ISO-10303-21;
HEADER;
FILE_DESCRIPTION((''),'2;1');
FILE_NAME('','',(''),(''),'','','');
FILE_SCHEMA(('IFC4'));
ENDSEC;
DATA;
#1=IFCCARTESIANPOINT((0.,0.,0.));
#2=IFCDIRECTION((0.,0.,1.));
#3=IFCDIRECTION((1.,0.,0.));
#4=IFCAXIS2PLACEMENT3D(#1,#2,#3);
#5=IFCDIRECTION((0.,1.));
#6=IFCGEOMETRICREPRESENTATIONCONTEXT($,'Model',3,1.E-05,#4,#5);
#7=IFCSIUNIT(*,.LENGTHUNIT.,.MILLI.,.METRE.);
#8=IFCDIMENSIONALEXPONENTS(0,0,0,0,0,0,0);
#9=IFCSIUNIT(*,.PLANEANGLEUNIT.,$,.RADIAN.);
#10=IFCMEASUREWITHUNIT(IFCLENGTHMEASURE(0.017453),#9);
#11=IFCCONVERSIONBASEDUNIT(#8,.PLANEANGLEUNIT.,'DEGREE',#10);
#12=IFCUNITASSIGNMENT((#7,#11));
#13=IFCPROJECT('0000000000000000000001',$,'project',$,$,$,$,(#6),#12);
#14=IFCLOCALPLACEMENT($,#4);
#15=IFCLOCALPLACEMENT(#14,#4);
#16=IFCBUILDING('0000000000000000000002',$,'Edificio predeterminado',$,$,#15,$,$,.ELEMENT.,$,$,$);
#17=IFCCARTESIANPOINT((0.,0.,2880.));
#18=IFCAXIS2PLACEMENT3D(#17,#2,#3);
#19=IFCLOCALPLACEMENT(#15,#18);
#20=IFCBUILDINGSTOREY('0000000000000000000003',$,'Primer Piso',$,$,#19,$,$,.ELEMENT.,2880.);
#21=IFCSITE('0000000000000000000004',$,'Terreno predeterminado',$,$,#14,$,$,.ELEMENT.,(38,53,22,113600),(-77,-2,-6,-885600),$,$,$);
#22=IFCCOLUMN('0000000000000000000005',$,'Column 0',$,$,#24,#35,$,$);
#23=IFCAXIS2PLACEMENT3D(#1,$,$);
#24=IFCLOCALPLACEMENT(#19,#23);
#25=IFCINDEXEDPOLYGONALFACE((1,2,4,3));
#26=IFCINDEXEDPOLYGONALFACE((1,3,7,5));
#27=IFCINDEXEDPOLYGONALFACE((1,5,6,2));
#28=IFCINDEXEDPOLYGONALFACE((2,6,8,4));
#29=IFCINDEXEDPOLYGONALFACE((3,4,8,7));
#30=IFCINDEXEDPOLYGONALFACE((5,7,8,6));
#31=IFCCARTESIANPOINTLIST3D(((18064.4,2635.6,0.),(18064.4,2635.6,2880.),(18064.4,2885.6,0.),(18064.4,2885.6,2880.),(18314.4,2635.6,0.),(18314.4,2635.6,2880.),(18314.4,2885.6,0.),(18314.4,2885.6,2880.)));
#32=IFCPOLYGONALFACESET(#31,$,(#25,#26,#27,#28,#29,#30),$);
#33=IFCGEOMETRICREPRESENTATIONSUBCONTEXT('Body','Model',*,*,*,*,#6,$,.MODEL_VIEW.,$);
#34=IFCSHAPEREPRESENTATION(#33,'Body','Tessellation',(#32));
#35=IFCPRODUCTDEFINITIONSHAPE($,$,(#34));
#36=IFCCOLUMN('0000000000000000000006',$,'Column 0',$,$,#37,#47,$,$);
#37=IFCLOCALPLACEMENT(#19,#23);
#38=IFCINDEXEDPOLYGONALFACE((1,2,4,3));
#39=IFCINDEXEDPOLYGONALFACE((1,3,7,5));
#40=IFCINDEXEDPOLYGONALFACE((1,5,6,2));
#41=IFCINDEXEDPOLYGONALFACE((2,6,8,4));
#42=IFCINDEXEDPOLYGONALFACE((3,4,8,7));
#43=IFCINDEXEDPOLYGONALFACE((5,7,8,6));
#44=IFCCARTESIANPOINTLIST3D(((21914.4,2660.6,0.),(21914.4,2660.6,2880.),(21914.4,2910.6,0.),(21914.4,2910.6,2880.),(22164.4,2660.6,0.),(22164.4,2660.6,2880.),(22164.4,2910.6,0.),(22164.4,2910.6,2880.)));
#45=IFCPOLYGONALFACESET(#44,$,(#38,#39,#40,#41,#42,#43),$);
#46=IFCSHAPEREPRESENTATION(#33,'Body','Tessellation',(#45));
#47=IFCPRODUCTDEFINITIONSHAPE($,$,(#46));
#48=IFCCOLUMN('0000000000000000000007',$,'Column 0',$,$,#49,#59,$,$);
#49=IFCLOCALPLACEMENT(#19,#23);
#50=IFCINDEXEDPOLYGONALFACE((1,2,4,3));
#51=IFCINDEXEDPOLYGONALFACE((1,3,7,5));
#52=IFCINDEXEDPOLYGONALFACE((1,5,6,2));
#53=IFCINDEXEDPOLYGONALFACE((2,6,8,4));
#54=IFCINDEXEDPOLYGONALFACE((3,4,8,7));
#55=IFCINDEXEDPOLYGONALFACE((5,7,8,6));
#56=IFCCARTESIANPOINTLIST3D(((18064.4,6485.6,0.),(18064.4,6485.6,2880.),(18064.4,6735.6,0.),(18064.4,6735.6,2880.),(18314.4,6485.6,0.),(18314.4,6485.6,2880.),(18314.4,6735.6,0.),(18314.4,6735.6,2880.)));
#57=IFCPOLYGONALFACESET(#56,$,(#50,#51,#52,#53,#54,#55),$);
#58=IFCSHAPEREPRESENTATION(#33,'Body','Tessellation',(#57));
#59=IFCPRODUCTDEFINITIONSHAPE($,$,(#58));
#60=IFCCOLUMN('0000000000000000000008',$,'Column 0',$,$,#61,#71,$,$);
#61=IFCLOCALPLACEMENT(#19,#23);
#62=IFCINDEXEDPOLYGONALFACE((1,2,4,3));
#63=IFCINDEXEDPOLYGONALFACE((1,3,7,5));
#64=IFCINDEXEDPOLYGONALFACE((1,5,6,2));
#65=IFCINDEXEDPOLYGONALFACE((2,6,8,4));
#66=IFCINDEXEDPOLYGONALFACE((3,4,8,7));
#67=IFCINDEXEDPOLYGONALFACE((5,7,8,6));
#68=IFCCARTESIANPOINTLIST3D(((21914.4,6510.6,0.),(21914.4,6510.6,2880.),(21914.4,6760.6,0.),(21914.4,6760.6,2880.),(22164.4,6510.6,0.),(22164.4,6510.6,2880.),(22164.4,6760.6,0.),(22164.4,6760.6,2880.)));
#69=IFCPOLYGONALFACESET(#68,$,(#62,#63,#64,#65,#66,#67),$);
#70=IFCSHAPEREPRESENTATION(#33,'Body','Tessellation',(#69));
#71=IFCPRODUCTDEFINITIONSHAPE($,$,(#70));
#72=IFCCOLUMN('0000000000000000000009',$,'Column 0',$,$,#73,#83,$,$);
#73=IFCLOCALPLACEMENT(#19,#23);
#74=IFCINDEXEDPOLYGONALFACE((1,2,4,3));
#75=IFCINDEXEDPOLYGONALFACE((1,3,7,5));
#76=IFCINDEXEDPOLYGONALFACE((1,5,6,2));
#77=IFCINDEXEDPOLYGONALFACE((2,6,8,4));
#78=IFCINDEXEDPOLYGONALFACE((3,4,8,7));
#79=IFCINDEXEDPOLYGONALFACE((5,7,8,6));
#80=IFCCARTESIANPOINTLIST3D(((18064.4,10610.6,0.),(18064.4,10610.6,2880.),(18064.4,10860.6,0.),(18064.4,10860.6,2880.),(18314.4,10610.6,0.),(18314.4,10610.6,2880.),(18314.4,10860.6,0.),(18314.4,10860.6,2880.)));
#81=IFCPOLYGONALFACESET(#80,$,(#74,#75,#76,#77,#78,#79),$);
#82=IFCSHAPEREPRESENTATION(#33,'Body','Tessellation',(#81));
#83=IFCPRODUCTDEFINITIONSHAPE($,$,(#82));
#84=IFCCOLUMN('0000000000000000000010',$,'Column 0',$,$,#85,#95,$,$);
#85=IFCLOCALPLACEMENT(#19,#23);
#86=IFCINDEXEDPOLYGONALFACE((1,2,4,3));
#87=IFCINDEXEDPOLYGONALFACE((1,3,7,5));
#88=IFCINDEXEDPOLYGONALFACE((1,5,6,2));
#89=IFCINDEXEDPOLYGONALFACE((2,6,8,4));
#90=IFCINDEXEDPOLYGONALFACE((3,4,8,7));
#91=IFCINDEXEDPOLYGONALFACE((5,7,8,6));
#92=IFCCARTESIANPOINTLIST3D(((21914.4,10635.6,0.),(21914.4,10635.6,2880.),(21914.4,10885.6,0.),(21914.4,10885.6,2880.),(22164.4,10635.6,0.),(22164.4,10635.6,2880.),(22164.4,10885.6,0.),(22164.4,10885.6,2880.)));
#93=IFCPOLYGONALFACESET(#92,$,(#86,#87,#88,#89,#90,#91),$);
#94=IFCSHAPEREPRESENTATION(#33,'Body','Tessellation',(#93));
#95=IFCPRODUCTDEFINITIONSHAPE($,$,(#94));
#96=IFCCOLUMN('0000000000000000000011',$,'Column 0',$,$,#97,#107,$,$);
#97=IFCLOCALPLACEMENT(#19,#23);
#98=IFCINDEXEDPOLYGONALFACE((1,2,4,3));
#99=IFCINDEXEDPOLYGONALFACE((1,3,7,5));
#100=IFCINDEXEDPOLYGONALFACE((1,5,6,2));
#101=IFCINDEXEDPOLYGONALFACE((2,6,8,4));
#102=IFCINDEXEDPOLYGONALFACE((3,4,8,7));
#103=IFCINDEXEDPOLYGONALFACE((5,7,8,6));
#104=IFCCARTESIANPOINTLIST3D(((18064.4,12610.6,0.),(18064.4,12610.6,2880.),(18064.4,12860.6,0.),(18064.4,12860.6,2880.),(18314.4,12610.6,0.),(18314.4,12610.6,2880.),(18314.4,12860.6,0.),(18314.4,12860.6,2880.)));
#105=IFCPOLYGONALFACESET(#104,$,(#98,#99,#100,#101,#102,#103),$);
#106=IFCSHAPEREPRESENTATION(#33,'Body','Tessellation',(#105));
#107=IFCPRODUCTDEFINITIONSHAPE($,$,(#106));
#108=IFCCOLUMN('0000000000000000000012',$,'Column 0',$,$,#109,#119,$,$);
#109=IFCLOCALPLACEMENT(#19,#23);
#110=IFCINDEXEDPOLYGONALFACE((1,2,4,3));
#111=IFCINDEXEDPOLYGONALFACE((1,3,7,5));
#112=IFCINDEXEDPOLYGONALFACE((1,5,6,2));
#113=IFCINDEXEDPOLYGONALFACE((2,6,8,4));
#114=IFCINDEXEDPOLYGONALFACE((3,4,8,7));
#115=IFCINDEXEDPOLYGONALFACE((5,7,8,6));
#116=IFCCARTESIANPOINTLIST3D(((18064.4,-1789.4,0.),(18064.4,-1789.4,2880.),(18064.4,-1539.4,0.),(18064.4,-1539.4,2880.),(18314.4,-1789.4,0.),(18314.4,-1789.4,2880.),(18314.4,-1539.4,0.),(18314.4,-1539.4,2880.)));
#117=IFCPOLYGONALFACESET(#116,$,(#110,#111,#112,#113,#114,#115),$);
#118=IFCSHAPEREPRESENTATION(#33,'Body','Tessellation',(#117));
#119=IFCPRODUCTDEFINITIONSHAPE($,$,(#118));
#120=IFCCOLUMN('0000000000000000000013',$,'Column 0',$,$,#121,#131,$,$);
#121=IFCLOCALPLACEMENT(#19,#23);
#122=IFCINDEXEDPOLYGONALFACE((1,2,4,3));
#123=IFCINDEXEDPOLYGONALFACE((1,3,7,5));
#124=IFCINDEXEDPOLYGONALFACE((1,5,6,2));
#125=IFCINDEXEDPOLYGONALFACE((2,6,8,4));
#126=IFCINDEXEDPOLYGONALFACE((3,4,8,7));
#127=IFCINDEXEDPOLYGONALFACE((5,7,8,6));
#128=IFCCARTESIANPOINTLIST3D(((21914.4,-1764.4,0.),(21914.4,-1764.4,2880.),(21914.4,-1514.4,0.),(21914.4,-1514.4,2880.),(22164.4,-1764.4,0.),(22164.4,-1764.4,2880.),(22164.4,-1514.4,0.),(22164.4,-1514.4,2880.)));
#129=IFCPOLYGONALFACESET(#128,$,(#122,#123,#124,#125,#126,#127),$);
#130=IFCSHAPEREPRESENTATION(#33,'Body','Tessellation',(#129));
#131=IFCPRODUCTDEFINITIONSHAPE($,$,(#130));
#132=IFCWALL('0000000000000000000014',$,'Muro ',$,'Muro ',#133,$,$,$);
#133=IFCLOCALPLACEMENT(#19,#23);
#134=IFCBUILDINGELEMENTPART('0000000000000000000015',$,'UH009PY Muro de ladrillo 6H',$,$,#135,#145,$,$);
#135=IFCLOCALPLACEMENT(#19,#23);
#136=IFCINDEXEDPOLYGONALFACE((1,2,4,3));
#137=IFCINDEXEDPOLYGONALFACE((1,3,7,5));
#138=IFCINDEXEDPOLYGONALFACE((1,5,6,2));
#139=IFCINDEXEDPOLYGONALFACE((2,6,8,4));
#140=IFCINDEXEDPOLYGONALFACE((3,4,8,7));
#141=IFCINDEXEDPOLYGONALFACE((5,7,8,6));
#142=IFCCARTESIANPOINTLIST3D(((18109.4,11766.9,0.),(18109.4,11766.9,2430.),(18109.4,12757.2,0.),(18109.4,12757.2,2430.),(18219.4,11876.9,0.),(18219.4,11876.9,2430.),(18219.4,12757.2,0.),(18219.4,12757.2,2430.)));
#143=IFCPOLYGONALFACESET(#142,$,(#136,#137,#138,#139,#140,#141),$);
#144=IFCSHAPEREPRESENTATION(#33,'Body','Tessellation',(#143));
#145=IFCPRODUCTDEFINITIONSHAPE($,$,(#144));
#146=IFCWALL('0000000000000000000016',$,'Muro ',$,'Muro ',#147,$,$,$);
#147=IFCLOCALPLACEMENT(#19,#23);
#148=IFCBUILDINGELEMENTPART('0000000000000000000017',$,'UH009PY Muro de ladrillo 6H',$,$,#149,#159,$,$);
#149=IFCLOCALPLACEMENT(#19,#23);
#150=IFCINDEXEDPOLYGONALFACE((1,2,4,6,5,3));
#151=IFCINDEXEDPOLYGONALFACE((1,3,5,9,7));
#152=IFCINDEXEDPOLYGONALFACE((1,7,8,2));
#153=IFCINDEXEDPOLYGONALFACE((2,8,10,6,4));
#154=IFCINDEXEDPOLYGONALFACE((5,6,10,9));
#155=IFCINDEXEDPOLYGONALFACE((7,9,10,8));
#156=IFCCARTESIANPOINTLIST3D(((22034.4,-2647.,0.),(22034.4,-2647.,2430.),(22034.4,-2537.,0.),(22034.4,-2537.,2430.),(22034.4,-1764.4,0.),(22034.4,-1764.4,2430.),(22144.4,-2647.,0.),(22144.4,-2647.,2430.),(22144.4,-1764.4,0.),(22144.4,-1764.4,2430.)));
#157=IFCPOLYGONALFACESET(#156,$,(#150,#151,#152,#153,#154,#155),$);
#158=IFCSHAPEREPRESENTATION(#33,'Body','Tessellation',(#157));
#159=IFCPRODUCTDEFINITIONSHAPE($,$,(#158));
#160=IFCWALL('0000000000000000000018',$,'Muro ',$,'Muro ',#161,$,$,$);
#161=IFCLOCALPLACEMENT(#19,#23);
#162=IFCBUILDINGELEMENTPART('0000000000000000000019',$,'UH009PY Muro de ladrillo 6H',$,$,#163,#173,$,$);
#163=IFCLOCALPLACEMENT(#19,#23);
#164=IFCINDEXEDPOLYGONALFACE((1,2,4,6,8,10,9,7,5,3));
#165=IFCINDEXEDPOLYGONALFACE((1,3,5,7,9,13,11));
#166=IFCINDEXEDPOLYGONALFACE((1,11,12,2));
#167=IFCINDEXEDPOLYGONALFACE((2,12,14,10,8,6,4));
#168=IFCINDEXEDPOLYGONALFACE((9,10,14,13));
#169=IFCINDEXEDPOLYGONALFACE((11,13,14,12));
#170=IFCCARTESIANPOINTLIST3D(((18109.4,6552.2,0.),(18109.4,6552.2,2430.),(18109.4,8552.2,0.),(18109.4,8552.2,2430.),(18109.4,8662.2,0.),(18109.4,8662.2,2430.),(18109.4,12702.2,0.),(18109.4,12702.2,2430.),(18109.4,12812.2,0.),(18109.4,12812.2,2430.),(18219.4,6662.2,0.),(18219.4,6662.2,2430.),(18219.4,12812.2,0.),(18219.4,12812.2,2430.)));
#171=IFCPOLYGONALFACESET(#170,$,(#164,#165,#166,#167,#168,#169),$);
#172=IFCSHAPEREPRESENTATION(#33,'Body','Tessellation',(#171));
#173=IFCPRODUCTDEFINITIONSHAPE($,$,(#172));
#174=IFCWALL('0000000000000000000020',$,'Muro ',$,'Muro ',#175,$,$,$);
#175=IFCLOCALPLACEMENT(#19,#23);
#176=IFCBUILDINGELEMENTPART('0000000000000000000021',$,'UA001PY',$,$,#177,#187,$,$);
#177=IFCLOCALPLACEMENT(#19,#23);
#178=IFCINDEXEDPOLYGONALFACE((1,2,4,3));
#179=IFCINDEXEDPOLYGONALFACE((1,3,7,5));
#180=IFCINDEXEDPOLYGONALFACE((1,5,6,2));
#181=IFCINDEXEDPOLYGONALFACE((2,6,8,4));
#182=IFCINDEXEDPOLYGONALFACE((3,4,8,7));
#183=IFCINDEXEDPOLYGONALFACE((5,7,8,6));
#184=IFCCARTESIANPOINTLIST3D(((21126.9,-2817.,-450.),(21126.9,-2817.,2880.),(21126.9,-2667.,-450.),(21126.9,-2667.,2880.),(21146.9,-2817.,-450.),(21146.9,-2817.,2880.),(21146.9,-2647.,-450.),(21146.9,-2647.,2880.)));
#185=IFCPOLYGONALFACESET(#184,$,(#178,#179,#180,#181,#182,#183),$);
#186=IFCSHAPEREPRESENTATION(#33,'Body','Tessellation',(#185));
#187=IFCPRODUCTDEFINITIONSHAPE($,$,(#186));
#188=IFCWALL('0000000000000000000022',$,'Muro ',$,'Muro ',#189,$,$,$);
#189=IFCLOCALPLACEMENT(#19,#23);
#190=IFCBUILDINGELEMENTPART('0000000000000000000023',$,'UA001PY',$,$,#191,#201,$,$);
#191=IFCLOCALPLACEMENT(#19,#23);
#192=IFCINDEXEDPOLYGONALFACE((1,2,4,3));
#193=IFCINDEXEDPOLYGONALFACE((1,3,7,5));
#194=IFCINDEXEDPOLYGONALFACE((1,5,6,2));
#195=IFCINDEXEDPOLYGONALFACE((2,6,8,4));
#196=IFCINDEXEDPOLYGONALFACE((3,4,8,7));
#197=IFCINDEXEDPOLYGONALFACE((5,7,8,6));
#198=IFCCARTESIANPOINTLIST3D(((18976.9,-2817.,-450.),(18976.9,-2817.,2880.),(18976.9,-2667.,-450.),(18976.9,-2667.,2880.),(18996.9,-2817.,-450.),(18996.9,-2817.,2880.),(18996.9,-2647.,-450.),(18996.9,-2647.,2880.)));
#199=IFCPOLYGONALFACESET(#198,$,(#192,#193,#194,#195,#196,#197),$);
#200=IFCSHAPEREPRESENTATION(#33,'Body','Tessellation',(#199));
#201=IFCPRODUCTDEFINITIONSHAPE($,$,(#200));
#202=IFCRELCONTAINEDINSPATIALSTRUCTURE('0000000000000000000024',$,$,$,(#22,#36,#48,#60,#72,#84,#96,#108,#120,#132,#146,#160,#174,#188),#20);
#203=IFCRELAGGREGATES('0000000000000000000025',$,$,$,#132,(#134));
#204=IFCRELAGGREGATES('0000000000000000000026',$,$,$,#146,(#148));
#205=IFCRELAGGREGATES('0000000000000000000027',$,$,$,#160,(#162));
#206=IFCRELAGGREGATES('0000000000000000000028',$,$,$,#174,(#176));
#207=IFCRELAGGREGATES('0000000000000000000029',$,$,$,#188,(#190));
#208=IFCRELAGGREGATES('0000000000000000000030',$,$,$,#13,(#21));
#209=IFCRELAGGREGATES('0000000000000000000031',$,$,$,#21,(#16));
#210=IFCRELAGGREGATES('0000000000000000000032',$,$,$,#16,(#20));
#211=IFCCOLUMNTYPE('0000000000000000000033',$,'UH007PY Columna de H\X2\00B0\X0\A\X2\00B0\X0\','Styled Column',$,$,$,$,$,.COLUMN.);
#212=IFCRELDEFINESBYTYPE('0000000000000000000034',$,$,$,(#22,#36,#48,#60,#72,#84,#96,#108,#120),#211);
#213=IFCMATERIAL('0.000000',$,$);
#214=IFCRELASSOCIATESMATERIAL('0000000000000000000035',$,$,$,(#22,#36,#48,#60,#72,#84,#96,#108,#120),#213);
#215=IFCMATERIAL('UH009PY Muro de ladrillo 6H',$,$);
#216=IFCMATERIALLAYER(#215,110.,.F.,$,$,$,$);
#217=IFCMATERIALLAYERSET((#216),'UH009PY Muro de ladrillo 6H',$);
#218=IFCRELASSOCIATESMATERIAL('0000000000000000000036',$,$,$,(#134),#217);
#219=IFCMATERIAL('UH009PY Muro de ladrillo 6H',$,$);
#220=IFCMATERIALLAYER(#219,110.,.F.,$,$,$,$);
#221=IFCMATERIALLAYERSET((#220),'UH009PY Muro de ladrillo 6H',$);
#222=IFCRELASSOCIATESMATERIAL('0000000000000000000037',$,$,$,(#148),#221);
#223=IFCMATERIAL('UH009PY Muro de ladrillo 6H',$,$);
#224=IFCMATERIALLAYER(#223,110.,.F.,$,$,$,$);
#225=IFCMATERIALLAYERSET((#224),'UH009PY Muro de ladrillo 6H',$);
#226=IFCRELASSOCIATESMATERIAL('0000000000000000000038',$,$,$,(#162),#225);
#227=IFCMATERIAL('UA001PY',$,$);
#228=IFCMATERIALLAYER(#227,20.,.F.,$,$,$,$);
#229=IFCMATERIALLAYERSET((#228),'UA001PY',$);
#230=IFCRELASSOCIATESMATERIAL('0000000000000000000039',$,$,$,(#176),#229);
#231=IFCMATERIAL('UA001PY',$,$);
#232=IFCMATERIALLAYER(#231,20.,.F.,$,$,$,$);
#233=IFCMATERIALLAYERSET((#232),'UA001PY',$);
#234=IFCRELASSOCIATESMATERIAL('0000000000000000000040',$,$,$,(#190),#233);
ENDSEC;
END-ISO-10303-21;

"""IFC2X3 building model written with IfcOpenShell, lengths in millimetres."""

from ifc_helpers import new_model, entity, si_unit, converted_unit, direction, frame, origin_with_axes, place, context, subcontext, project, spatial, polyline, outline, extrude, clip, bounded_halfspace, material, layer, layer_set, layer_usage, type_object, element, aggregate, save


model = new_model("IFC2X3")

# Units and contexts
model_context = context("Model", 3, precision=1e-05, world=origin_with_axes(), true_north=direction((0.0, 1.0)))
body_context = subcontext(model_context, "Body", "Model", "MODEL_VIEW")
ifc_project = project(units=[si_unit("LENGTHUNIT", "METRE", prefix="MILLI"), converted_unit("PLANEANGLEUNIT", "DEGREE", entity("IfcLengthMeasure", 0.017453), si_unit("PLANEANGLEUNIT", "RADIAN"), dimensions=[0, 0, 0, 0, 0, 0, 0])], contexts=[model_context])

# Site, building, storey
site_placement = place(None, origin_with_axes())
site = spatial("IfcSite", under=ifc_project, at=site_placement, Name="Terreno predeterminado", CompositionType="ELEMENT", RefLatitude=(38, 53, 22, 113600), RefLongitude=(-77, -2, -6, -885600))
building_placement = place(site_placement, origin_with_axes())
building = spatial("IfcBuilding", under=site, at=building_placement, Name="Edificio predeterminado", CompositionType="ELEMENT")
storey_placement = place(building_placement, frame((0.0, 0.0, 2880.0), z_axis=(0.0, 0.0, 1.0), x_axis=(1.0, 0.0, 0.0)))
storey = spatial("IfcBuildingStorey", under=building, at=storey_placement, Name="Primer Piso", CompositionType="ELEMENT", Elevation=2880.0)

# Columns
ifc_material_1 = material(Name="0.000000")
column_type = type_object("IfcColumnType", Name="UH007PY Columna de H°A°", Description="Styled Column", PredefinedType="COLUMN")
for number, where, z_axis, x_axis, name in (
    (1, (18189.4, 2760.6, 0.0), (0.0, 0.0, 1.0), (1.0, 0.0, 0.0), "Column 0"),
    (2, (22039.4, 2785.6, 0.0), (0.0, 0.0, 1.0), (1.0, 0.0, 0.0), "Column 0"),
    (3, (18189.4, 6610.6, 0.0), (0.0, 0.0, 1.0), (1.0, 0.0, 0.0), "Column 0"),
    (4, (22039.4, 6635.6, 0.0), (0.0, 0.0, 1.0), (1.0, 0.0, 0.0), "Column 0"),
    (5, (18189.4, 10735.6, 0.0), (0.0, 0.0, 1.0), (1.0, 0.0, 0.0), "Column 0"),
    (6, (22039.4, 10760.6, 0.0), (0.0, 0.0, 1.0), (1.0, 0.0, 0.0), "Column 0"),
    (7, (18189.4, 12735.6, 0.0), (0.0, 0.0, 1.0), (1.0, 0.0, 0.0), "Column 0"),
    (8, (18189.4, -1664.4, 0.0), (0.0, 0.0, 1.0), (1.0, 0.0, 0.0), "Column 0"),
    (9, (22039.4, -1639.4, 0.0), (0.0, 0.0, 1.0), (1.0, 0.0, 0.0), "Column 0"),
):
    element("IfcColumn", number, at=place(storey_placement, frame(where, z_axis=z_axis, x_axis=x_axis)), inside=storey, type_object=column_type, material=ifc_material_1, Name=name, context=body_context, shape_type="SweptSolid", body=[
        extrude(outline(polyline([(-125.0, -125.0), (125.0, -125.0), (125.0, 125.0), (-125.0, 125.0), (-125.0, -125.0)])), origin_with_axes(), (0.0, 0.0, 1.0), 2880.0),
    ])

# Walls, building element parts
wall_1_placement = place(storey_placement, frame((18164.4, 11821.9, 0.0), z_axis=(0.0, 0.0, 1.0), x_axis=(0.0, 1.0, 0.0)))
wall_1 = element("IfcWall", 10, at=wall_1_placement, inside=storey, Name="Muro ", ObjectType="Muro ")
ifc_material_2 = material(Name="UH009PY Muro de ladrillo 6H")
ifc_layer_1 = layer(ifc_material_2, 110.0, ventilated=False)
ifc_layer_set_1 = layer_set([ifc_layer_1], Name="UH009PY Muro de ladrillo 6H")
ifc_layer_usage_1 = layer_usage(ifc_layer_set_1, "AXIS2", "NEGATIVE", -55.0)
building_element_part_1_placement = place(wall_1_placement, origin_with_axes())
building_element_part_1 = element("IfcBuildingElementPart", 11, at=building_element_part_1_placement, material=ifc_layer_usage_1, Name="UH009PY Muro de ladrillo 6H", context=body_context, shape_type="SweptSolid", body=[
    extrude(outline(polyline([(935.2, 55.0), (935.2, -55.0), (55.0, -55.0), (-55.0, 55.0), (935.2, 55.0)])), origin_with_axes(), (0.0, 0.0, 1.0), 2430.0),
])
aggregate(wall_1, [building_element_part_1])
wall_2_placement = place(storey_placement, frame((22089.4, -1764.4, 0.0), z_axis=(0.0, 0.0, 1.0), x_axis=(0.0, -1.0, 0.0)))
wall_2 = element("IfcWall", 12, at=wall_2_placement, inside=storey, Name="Muro ", ObjectType="Muro ")
ifc_material_3 = material(Name="UH009PY Muro de ladrillo 6H")
ifc_layer_2 = layer(ifc_material_3, 110.0, ventilated=False)
ifc_layer_set_2 = layer_set([ifc_layer_2], Name="UH009PY Muro de ladrillo 6H")
ifc_layer_usage_2 = layer_usage(ifc_layer_set_2, "AXIS2", "NEGATIVE", -55.0)
building_element_part_2_placement = place(wall_2_placement, origin_with_axes())
building_element_part_2 = element("IfcBuildingElementPart", 13, at=building_element_part_2_placement, material=ifc_layer_usage_2, Name="UH009PY Muro de ladrillo 6H", context=body_context, shape_type="SweptSolid", body=[
    extrude(outline(polyline([(882.6, 55.0), (882.6, -55.0), (772.6, -55.0), (0.0, -55.0), (0.0, 55.0), (882.6, 55.0)])), origin_with_axes(), (0.0, 0.0, 1.0), 2430.0),
])
aggregate(wall_2, [building_element_part_2])
wall_3_placement = place(storey_placement, frame((18164.4, 12757.2, 0.0), z_axis=(0.0, 0.0, 1.0), x_axis=(0.0, -1.0, 0.0)))
wall_3 = element("IfcWall", 14, at=wall_3_placement, inside=storey, Name="Muro ", ObjectType="Muro ")
ifc_material_4 = material(Name="UH009PY Muro de ladrillo 6H")
ifc_layer_3 = layer(ifc_material_4, 110.0, ventilated=False)
ifc_layer_set_3 = layer_set([ifc_layer_3], Name="UH009PY Muro de ladrillo 6H")
ifc_layer_usage_3 = layer_usage(ifc_layer_set_3, "AXIS2", "NEGATIVE", -55.0)
building_element_part_3_placement = place(wall_3_placement, origin_with_axes())
building_element_part_3 = element("IfcBuildingElementPart", 15, at=building_element_part_3_placement, material=ifc_layer_usage_3, Name="UH009PY Muro de ladrillo 6H", context=body_context, shape_type="SweptSolid", body=[
    extrude(outline(polyline([(6095.0, 55.0), (6205.0, -55.0), (4205.0, -55.0), (4095.0, -55.0), (55.0, -55.0), (-55.0, -55.0), (-55.0, 55.0), (6095.0, 55.0)])), origin_with_axes(), (0.0, 0.0, 1.0), 2430.0),
])
aggregate(wall_3, [building_element_part_3])
wall_4_placement = place(storey_placement, frame((21201.9, -2817.0, 0.0), z_axis=(0.0, 0.0, 1.0), x_axis=(0.0, 1.0, 0.0)))
wall_4 = element("IfcWall", 16, at=wall_4_placement, inside=storey, Name="Muro ", ObjectType="Muro ")
ifc_material_5 = material(Name="UA001PY")
ifc_layer_4 = layer(ifc_material_5, 20.0, ventilated=False)
ifc_layer_set_4 = layer_set([ifc_layer_4], Name="UA001PY")
ifc_layer_usage_4 = layer_usage(ifc_layer_set_4, "AXIS2", "NEGATIVE", -75.0)
building_element_part_4_placement = place(wall_4_placement, origin_with_axes())
building_element_part_4 = element("IfcBuildingElementPart", 17, at=building_element_part_4_placement, material=ifc_layer_usage_4, Name="UA001PY", context=body_context, shape_type="Clipping", body=[
    clip(clip(extrude(outline(polyline([(150.0, 75.0), (170.0, 55.0), (0.0, 55.0), (0.0, 75.0), (150.0, 75.0)])), frame((0.0, 0.0, -450.0), z_axis=(0.0, 0.0, 1.0), x_axis=(1.0, 0.0, 0.0)), (0.0, 0.0, 1.0), 3330.0), bounded_halfspace(frame((0.0, 0.0, -450.0), z_axis=(0.0, 0.0, 1.0), x_axis=(1.0, 0.0, 0.0)), True, origin_with_axes(), polyline([(-150.0, -150.0), (375.0, -150.0), (375.0, 150.0), (-150.0, 150.0), (-150.0, -150.0)]))), bounded_halfspace(frame((0.0, 0.0, 2880.0), z_axis=(0.0, 0.0, 1.0), x_axis=(1.0, 0.0, 0.0)), False, origin_with_axes(), polyline([(-150.0, -150.0), (375.0, -150.0), (375.0, 150.0), (-150.0, 150.0), (-150.0, -150.0)]))),
])
aggregate(wall_4, [building_element_part_4])
wall_5_placement = place(storey_placement, frame((19051.9, -2817.0, 0.0), z_axis=(0.0, 0.0, 1.0), x_axis=(0.0, 1.0, 0.0)))
wall_5 = element("IfcWall", 18, at=wall_5_placement, inside=storey, Name="Muro ", ObjectType="Muro ")
ifc_material_6 = material(Name="UA001PY")
ifc_layer_5 = layer(ifc_material_6, 20.0, ventilated=False)
ifc_layer_set_5 = layer_set([ifc_layer_5], Name="UA001PY")
ifc_layer_usage_5 = layer_usage(ifc_layer_set_5, "AXIS2", "NEGATIVE", -75.0)
building_element_part_5_placement = place(wall_5_placement, origin_with_axes())
building_element_part_5 = element("IfcBuildingElementPart", 19, at=building_element_part_5_placement, material=ifc_layer_usage_5, Name="UA001PY", context=body_context, shape_type="Clipping", body=[
    clip(clip(extrude(outline(polyline([(150.0, 75.0), (170.0, 55.0), (0.0, 55.0), (0.0, 75.0), (150.0, 75.0)])), frame((0.0, 0.0, -450.0), z_axis=(0.0, 0.0, 1.0), x_axis=(1.0, 0.0, 0.0)), (0.0, 0.0, 1.0), 3330.0), bounded_halfspace(frame((0.0, 0.0, -450.0), z_axis=(0.0, 0.0, 1.0), x_axis=(1.0, 0.0, 0.0)), True, origin_with_axes(), polyline([(-150.0, -150.0), (375.0, -150.0), (375.0, 150.0), (-150.0, 150.0), (-150.0, -150.0)]))), bounded_halfspace(frame((0.0, 0.0, 2880.0), z_axis=(0.0, 0.0, 1.0), x_axis=(1.0, 0.0, 0.0)), False, origin_with_axes(), polyline([(-150.0, -150.0), (375.0, -150.0), (375.0, 150.0), (-150.0, 150.0), (-150.0, -150.0)]))),
])
aggregate(wall_5, [building_element_part_5])

save(model, "model.ifc")
